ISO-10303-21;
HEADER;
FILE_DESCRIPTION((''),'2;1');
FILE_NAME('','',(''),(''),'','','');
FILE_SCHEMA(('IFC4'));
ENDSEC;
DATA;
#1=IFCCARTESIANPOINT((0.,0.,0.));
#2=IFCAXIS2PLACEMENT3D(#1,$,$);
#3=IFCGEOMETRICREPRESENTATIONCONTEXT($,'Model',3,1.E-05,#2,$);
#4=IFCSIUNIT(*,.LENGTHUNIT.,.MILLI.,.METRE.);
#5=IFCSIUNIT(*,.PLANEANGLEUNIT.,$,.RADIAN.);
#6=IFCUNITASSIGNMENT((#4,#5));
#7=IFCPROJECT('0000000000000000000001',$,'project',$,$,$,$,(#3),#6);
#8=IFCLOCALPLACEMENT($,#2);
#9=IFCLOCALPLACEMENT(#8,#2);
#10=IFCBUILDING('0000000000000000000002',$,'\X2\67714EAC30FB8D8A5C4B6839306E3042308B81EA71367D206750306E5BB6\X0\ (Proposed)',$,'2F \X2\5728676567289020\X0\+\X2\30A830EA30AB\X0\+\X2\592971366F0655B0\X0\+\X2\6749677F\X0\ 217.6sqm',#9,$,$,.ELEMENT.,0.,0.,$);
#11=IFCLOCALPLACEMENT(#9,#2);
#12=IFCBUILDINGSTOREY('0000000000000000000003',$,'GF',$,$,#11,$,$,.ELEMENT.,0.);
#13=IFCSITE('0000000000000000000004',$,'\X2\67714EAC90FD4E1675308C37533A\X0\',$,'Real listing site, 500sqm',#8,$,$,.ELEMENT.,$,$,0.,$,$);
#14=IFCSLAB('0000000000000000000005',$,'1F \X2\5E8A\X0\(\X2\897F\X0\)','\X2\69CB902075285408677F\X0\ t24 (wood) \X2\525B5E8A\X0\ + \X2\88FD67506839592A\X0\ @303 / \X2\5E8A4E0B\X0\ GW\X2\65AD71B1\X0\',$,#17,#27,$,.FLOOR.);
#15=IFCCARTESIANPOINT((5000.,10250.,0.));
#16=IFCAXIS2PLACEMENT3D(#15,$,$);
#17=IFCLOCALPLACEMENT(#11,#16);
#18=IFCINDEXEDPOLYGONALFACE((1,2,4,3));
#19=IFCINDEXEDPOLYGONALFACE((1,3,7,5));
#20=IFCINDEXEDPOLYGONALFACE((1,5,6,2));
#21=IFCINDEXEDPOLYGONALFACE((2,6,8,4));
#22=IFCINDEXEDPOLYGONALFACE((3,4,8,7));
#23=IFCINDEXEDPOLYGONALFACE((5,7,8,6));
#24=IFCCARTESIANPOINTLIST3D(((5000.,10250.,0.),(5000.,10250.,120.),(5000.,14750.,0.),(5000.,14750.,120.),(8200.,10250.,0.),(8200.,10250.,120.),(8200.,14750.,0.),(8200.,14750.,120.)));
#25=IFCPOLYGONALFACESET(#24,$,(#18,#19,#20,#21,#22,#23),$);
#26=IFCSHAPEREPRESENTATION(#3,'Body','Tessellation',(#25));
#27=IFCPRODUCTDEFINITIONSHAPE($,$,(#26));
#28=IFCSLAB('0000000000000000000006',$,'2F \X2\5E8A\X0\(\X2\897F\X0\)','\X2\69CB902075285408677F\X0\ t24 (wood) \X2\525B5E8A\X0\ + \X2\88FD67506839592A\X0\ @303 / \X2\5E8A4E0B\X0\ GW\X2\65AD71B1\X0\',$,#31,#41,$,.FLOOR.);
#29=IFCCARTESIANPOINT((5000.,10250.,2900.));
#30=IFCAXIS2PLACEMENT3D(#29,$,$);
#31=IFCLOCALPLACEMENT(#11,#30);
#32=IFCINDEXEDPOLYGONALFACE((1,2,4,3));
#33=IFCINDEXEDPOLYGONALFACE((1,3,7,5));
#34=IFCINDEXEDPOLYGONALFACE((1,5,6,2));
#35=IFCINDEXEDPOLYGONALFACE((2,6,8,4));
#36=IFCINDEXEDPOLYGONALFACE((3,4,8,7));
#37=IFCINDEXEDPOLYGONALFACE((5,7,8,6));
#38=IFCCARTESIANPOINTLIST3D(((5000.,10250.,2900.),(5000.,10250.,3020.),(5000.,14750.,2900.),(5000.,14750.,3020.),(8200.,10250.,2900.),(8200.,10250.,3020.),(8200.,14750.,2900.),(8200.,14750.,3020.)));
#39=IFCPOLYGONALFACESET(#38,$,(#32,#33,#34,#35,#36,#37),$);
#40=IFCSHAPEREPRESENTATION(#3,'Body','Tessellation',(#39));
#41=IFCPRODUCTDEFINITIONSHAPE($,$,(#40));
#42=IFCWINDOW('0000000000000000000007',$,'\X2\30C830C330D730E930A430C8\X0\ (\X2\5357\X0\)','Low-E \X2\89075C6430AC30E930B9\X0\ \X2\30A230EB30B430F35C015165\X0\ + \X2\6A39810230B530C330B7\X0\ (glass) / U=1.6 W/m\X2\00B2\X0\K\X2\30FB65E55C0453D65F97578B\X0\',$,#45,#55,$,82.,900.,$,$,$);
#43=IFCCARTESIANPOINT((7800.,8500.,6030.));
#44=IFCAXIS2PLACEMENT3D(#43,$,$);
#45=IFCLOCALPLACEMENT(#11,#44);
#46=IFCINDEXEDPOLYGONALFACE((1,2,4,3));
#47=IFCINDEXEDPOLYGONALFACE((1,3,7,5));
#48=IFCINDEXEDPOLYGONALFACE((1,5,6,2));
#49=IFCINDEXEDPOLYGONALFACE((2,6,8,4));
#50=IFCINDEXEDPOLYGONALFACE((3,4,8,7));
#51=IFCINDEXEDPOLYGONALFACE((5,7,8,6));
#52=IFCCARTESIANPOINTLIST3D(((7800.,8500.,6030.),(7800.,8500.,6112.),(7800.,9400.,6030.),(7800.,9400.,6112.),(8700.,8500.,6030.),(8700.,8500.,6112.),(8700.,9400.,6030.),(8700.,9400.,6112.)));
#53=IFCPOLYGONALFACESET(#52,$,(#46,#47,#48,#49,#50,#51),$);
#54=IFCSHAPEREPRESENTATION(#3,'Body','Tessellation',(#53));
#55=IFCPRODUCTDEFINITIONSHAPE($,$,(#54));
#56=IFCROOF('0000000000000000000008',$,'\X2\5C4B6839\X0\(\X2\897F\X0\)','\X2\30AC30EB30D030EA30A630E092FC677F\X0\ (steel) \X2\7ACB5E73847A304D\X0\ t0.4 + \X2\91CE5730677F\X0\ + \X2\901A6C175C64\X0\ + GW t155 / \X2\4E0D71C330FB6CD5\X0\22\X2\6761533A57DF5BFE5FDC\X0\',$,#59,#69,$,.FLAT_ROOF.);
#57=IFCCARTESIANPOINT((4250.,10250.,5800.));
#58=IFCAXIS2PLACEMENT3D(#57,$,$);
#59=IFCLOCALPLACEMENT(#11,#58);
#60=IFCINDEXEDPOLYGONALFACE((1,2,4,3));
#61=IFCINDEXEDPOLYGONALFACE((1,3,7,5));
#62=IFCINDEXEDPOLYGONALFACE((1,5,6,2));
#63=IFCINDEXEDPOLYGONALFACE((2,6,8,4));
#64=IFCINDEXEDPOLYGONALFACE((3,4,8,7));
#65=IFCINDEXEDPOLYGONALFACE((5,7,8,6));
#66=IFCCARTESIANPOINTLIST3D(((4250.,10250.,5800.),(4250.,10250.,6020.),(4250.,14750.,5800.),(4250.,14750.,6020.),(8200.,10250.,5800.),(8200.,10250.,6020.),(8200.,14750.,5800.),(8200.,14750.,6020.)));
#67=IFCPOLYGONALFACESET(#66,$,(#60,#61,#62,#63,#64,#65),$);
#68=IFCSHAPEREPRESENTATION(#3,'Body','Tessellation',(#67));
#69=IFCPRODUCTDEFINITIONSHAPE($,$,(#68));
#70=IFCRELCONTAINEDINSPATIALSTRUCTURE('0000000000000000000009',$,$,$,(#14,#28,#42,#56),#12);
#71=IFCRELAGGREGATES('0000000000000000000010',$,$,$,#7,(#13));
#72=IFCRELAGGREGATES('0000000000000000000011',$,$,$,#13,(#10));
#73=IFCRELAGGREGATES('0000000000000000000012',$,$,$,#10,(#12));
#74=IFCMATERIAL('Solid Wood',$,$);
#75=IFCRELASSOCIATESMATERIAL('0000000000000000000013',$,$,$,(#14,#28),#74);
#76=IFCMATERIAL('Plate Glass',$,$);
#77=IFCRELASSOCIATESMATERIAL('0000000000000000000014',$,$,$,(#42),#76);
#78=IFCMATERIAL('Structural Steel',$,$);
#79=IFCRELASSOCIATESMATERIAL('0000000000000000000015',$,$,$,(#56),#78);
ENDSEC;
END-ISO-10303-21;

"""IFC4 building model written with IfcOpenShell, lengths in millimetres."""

from ifc_helpers import new_model, si_unit, frame, frame_2d, origin, place, context, project, spatial, rectangle, extrude, material, element, save


model = new_model("IFC4")

# Units and contexts
model_context = context("Model", 3, precision=1e-05, world=origin())
ifc_project = project(units=[si_unit("LENGTHUNIT", "METRE", prefix="MILLI"), si_unit("PLANEANGLEUNIT", "RADIAN")], contexts=[model_context])

# Site, building, storey
site_placement = place(None, origin())
site = spatial("IfcSite", under=ifc_project, at=site_placement, Name="東京都世田谷区", ObjectType="Real listing site, 500sqm", CompositionType="ELEMENT", RefElevation=0.0)
building_placement = place(site_placement, origin())
building = spatial("IfcBuilding", under=site, at=building_placement, Name="東京・越屋根のある自然素材の家 (Proposed)", ObjectType="2F 在来木造+エリカ+天然漆喰+杉板 217.6sqm", CompositionType="ELEMENT", ElevationOfRefHeight=0.0, ElevationOfTerrain=0.0)
storey_placement = place(building_placement, origin())
storey = spatial("IfcBuildingStorey", under=building, at=storey_placement, Name="GF", CompositionType="ELEMENT", Elevation=0.0)

# Shared definitions
ifc_material_1 = material(Name="Solid Wood")

# Slabs
slab_1_placement = place(storey_placement, frame((5000.0, 10250.0, 0.0)))
element("IfcSlab", 1, at=slab_1_placement, inside=storey, material=ifc_material_1, Name="1F 床(西)", Description="構造用合板 t24 (wood) 剛床 + 製材根太 @303 / 床下 GW断熱", PredefinedType="FLOOR", context=model_context, shape_type="SweptSolid", body=[
    extrude(rectangle(XDim=3200.0, YDim=4500.0, at=frame_2d((1600.0, 2250.0))), frame((5000.0, 10250.0, 0.0)), (0.0, 0.0, 1.0), 120.0),
])
slab_2_placement = place(storey_placement, frame((5000.0, 10250.0, 2900.0)))
element("IfcSlab", 2, at=slab_2_placement, inside=storey, material=ifc_material_1, Name="2F 床(西)", Description="構造用合板 t24 (wood) 剛床 + 製材根太 @303 / 床下 GW断熱", PredefinedType="FLOOR", context=model_context, shape_type="SweptSolid", body=[
    extrude(rectangle(XDim=3200.0, YDim=4500.0, at=frame_2d((1600.0, 2250.0))), frame((5000.0, 10250.0, 2900.0)), (0.0, 0.0, 1.0), 120.0),
])

# Window
ifc_material_2 = material(Name="Plate Glass")
window_placement = place(storey_placement, frame((7800.0, 8500.0, 6030.0)))
element("IfcWindow", 3, at=window_placement, inside=storey, material=ifc_material_2, Name="トップライト (南)", Description="Low-E 複層ガラス アルゴン封入 + 樹脂サッシ (glass) / U=1.6 W/m²K・日射取得型", OverallHeight=82.0, OverallWidth=900.0, context=model_context, shape_type="SweptSolid", body=[
    extrude(rectangle(XDim=900.0, YDim=900.0, at=frame_2d((450.0, 450.0))), frame((7800.0, 8500.0, 6030.0)), (0.0, 0.0, 1.0), 82.0),
])

# Roof
ifc_material_3 = material(Name="Structural Steel")
for number, where, name in (
    (4, (4250.0, 10250.0, 5800.0), "屋根(西)"),
):
    element("IfcRoof", number, at=place(storey_placement, frame(where)), inside=storey, material=ifc_material_3, Name=name, Description="ガルバリウム鋼板 (steel) 立平葺き t0.4 + 野地板 + 通気層 + GW t155 / 不燃・法22条区域対応", PredefinedType="FLAT_ROOF", context=model_context, shape_type="SweptSolid", body=[
        extrude(rectangle(XDim=3950.0, YDim=4500.0, at=frame_2d((1975.0, 2250.0))), frame((4250.0, 10250.0, 5800.0)), (0.0, 0.0, 1.0), 220.0),
    ])

save(model, "model.ifc")
